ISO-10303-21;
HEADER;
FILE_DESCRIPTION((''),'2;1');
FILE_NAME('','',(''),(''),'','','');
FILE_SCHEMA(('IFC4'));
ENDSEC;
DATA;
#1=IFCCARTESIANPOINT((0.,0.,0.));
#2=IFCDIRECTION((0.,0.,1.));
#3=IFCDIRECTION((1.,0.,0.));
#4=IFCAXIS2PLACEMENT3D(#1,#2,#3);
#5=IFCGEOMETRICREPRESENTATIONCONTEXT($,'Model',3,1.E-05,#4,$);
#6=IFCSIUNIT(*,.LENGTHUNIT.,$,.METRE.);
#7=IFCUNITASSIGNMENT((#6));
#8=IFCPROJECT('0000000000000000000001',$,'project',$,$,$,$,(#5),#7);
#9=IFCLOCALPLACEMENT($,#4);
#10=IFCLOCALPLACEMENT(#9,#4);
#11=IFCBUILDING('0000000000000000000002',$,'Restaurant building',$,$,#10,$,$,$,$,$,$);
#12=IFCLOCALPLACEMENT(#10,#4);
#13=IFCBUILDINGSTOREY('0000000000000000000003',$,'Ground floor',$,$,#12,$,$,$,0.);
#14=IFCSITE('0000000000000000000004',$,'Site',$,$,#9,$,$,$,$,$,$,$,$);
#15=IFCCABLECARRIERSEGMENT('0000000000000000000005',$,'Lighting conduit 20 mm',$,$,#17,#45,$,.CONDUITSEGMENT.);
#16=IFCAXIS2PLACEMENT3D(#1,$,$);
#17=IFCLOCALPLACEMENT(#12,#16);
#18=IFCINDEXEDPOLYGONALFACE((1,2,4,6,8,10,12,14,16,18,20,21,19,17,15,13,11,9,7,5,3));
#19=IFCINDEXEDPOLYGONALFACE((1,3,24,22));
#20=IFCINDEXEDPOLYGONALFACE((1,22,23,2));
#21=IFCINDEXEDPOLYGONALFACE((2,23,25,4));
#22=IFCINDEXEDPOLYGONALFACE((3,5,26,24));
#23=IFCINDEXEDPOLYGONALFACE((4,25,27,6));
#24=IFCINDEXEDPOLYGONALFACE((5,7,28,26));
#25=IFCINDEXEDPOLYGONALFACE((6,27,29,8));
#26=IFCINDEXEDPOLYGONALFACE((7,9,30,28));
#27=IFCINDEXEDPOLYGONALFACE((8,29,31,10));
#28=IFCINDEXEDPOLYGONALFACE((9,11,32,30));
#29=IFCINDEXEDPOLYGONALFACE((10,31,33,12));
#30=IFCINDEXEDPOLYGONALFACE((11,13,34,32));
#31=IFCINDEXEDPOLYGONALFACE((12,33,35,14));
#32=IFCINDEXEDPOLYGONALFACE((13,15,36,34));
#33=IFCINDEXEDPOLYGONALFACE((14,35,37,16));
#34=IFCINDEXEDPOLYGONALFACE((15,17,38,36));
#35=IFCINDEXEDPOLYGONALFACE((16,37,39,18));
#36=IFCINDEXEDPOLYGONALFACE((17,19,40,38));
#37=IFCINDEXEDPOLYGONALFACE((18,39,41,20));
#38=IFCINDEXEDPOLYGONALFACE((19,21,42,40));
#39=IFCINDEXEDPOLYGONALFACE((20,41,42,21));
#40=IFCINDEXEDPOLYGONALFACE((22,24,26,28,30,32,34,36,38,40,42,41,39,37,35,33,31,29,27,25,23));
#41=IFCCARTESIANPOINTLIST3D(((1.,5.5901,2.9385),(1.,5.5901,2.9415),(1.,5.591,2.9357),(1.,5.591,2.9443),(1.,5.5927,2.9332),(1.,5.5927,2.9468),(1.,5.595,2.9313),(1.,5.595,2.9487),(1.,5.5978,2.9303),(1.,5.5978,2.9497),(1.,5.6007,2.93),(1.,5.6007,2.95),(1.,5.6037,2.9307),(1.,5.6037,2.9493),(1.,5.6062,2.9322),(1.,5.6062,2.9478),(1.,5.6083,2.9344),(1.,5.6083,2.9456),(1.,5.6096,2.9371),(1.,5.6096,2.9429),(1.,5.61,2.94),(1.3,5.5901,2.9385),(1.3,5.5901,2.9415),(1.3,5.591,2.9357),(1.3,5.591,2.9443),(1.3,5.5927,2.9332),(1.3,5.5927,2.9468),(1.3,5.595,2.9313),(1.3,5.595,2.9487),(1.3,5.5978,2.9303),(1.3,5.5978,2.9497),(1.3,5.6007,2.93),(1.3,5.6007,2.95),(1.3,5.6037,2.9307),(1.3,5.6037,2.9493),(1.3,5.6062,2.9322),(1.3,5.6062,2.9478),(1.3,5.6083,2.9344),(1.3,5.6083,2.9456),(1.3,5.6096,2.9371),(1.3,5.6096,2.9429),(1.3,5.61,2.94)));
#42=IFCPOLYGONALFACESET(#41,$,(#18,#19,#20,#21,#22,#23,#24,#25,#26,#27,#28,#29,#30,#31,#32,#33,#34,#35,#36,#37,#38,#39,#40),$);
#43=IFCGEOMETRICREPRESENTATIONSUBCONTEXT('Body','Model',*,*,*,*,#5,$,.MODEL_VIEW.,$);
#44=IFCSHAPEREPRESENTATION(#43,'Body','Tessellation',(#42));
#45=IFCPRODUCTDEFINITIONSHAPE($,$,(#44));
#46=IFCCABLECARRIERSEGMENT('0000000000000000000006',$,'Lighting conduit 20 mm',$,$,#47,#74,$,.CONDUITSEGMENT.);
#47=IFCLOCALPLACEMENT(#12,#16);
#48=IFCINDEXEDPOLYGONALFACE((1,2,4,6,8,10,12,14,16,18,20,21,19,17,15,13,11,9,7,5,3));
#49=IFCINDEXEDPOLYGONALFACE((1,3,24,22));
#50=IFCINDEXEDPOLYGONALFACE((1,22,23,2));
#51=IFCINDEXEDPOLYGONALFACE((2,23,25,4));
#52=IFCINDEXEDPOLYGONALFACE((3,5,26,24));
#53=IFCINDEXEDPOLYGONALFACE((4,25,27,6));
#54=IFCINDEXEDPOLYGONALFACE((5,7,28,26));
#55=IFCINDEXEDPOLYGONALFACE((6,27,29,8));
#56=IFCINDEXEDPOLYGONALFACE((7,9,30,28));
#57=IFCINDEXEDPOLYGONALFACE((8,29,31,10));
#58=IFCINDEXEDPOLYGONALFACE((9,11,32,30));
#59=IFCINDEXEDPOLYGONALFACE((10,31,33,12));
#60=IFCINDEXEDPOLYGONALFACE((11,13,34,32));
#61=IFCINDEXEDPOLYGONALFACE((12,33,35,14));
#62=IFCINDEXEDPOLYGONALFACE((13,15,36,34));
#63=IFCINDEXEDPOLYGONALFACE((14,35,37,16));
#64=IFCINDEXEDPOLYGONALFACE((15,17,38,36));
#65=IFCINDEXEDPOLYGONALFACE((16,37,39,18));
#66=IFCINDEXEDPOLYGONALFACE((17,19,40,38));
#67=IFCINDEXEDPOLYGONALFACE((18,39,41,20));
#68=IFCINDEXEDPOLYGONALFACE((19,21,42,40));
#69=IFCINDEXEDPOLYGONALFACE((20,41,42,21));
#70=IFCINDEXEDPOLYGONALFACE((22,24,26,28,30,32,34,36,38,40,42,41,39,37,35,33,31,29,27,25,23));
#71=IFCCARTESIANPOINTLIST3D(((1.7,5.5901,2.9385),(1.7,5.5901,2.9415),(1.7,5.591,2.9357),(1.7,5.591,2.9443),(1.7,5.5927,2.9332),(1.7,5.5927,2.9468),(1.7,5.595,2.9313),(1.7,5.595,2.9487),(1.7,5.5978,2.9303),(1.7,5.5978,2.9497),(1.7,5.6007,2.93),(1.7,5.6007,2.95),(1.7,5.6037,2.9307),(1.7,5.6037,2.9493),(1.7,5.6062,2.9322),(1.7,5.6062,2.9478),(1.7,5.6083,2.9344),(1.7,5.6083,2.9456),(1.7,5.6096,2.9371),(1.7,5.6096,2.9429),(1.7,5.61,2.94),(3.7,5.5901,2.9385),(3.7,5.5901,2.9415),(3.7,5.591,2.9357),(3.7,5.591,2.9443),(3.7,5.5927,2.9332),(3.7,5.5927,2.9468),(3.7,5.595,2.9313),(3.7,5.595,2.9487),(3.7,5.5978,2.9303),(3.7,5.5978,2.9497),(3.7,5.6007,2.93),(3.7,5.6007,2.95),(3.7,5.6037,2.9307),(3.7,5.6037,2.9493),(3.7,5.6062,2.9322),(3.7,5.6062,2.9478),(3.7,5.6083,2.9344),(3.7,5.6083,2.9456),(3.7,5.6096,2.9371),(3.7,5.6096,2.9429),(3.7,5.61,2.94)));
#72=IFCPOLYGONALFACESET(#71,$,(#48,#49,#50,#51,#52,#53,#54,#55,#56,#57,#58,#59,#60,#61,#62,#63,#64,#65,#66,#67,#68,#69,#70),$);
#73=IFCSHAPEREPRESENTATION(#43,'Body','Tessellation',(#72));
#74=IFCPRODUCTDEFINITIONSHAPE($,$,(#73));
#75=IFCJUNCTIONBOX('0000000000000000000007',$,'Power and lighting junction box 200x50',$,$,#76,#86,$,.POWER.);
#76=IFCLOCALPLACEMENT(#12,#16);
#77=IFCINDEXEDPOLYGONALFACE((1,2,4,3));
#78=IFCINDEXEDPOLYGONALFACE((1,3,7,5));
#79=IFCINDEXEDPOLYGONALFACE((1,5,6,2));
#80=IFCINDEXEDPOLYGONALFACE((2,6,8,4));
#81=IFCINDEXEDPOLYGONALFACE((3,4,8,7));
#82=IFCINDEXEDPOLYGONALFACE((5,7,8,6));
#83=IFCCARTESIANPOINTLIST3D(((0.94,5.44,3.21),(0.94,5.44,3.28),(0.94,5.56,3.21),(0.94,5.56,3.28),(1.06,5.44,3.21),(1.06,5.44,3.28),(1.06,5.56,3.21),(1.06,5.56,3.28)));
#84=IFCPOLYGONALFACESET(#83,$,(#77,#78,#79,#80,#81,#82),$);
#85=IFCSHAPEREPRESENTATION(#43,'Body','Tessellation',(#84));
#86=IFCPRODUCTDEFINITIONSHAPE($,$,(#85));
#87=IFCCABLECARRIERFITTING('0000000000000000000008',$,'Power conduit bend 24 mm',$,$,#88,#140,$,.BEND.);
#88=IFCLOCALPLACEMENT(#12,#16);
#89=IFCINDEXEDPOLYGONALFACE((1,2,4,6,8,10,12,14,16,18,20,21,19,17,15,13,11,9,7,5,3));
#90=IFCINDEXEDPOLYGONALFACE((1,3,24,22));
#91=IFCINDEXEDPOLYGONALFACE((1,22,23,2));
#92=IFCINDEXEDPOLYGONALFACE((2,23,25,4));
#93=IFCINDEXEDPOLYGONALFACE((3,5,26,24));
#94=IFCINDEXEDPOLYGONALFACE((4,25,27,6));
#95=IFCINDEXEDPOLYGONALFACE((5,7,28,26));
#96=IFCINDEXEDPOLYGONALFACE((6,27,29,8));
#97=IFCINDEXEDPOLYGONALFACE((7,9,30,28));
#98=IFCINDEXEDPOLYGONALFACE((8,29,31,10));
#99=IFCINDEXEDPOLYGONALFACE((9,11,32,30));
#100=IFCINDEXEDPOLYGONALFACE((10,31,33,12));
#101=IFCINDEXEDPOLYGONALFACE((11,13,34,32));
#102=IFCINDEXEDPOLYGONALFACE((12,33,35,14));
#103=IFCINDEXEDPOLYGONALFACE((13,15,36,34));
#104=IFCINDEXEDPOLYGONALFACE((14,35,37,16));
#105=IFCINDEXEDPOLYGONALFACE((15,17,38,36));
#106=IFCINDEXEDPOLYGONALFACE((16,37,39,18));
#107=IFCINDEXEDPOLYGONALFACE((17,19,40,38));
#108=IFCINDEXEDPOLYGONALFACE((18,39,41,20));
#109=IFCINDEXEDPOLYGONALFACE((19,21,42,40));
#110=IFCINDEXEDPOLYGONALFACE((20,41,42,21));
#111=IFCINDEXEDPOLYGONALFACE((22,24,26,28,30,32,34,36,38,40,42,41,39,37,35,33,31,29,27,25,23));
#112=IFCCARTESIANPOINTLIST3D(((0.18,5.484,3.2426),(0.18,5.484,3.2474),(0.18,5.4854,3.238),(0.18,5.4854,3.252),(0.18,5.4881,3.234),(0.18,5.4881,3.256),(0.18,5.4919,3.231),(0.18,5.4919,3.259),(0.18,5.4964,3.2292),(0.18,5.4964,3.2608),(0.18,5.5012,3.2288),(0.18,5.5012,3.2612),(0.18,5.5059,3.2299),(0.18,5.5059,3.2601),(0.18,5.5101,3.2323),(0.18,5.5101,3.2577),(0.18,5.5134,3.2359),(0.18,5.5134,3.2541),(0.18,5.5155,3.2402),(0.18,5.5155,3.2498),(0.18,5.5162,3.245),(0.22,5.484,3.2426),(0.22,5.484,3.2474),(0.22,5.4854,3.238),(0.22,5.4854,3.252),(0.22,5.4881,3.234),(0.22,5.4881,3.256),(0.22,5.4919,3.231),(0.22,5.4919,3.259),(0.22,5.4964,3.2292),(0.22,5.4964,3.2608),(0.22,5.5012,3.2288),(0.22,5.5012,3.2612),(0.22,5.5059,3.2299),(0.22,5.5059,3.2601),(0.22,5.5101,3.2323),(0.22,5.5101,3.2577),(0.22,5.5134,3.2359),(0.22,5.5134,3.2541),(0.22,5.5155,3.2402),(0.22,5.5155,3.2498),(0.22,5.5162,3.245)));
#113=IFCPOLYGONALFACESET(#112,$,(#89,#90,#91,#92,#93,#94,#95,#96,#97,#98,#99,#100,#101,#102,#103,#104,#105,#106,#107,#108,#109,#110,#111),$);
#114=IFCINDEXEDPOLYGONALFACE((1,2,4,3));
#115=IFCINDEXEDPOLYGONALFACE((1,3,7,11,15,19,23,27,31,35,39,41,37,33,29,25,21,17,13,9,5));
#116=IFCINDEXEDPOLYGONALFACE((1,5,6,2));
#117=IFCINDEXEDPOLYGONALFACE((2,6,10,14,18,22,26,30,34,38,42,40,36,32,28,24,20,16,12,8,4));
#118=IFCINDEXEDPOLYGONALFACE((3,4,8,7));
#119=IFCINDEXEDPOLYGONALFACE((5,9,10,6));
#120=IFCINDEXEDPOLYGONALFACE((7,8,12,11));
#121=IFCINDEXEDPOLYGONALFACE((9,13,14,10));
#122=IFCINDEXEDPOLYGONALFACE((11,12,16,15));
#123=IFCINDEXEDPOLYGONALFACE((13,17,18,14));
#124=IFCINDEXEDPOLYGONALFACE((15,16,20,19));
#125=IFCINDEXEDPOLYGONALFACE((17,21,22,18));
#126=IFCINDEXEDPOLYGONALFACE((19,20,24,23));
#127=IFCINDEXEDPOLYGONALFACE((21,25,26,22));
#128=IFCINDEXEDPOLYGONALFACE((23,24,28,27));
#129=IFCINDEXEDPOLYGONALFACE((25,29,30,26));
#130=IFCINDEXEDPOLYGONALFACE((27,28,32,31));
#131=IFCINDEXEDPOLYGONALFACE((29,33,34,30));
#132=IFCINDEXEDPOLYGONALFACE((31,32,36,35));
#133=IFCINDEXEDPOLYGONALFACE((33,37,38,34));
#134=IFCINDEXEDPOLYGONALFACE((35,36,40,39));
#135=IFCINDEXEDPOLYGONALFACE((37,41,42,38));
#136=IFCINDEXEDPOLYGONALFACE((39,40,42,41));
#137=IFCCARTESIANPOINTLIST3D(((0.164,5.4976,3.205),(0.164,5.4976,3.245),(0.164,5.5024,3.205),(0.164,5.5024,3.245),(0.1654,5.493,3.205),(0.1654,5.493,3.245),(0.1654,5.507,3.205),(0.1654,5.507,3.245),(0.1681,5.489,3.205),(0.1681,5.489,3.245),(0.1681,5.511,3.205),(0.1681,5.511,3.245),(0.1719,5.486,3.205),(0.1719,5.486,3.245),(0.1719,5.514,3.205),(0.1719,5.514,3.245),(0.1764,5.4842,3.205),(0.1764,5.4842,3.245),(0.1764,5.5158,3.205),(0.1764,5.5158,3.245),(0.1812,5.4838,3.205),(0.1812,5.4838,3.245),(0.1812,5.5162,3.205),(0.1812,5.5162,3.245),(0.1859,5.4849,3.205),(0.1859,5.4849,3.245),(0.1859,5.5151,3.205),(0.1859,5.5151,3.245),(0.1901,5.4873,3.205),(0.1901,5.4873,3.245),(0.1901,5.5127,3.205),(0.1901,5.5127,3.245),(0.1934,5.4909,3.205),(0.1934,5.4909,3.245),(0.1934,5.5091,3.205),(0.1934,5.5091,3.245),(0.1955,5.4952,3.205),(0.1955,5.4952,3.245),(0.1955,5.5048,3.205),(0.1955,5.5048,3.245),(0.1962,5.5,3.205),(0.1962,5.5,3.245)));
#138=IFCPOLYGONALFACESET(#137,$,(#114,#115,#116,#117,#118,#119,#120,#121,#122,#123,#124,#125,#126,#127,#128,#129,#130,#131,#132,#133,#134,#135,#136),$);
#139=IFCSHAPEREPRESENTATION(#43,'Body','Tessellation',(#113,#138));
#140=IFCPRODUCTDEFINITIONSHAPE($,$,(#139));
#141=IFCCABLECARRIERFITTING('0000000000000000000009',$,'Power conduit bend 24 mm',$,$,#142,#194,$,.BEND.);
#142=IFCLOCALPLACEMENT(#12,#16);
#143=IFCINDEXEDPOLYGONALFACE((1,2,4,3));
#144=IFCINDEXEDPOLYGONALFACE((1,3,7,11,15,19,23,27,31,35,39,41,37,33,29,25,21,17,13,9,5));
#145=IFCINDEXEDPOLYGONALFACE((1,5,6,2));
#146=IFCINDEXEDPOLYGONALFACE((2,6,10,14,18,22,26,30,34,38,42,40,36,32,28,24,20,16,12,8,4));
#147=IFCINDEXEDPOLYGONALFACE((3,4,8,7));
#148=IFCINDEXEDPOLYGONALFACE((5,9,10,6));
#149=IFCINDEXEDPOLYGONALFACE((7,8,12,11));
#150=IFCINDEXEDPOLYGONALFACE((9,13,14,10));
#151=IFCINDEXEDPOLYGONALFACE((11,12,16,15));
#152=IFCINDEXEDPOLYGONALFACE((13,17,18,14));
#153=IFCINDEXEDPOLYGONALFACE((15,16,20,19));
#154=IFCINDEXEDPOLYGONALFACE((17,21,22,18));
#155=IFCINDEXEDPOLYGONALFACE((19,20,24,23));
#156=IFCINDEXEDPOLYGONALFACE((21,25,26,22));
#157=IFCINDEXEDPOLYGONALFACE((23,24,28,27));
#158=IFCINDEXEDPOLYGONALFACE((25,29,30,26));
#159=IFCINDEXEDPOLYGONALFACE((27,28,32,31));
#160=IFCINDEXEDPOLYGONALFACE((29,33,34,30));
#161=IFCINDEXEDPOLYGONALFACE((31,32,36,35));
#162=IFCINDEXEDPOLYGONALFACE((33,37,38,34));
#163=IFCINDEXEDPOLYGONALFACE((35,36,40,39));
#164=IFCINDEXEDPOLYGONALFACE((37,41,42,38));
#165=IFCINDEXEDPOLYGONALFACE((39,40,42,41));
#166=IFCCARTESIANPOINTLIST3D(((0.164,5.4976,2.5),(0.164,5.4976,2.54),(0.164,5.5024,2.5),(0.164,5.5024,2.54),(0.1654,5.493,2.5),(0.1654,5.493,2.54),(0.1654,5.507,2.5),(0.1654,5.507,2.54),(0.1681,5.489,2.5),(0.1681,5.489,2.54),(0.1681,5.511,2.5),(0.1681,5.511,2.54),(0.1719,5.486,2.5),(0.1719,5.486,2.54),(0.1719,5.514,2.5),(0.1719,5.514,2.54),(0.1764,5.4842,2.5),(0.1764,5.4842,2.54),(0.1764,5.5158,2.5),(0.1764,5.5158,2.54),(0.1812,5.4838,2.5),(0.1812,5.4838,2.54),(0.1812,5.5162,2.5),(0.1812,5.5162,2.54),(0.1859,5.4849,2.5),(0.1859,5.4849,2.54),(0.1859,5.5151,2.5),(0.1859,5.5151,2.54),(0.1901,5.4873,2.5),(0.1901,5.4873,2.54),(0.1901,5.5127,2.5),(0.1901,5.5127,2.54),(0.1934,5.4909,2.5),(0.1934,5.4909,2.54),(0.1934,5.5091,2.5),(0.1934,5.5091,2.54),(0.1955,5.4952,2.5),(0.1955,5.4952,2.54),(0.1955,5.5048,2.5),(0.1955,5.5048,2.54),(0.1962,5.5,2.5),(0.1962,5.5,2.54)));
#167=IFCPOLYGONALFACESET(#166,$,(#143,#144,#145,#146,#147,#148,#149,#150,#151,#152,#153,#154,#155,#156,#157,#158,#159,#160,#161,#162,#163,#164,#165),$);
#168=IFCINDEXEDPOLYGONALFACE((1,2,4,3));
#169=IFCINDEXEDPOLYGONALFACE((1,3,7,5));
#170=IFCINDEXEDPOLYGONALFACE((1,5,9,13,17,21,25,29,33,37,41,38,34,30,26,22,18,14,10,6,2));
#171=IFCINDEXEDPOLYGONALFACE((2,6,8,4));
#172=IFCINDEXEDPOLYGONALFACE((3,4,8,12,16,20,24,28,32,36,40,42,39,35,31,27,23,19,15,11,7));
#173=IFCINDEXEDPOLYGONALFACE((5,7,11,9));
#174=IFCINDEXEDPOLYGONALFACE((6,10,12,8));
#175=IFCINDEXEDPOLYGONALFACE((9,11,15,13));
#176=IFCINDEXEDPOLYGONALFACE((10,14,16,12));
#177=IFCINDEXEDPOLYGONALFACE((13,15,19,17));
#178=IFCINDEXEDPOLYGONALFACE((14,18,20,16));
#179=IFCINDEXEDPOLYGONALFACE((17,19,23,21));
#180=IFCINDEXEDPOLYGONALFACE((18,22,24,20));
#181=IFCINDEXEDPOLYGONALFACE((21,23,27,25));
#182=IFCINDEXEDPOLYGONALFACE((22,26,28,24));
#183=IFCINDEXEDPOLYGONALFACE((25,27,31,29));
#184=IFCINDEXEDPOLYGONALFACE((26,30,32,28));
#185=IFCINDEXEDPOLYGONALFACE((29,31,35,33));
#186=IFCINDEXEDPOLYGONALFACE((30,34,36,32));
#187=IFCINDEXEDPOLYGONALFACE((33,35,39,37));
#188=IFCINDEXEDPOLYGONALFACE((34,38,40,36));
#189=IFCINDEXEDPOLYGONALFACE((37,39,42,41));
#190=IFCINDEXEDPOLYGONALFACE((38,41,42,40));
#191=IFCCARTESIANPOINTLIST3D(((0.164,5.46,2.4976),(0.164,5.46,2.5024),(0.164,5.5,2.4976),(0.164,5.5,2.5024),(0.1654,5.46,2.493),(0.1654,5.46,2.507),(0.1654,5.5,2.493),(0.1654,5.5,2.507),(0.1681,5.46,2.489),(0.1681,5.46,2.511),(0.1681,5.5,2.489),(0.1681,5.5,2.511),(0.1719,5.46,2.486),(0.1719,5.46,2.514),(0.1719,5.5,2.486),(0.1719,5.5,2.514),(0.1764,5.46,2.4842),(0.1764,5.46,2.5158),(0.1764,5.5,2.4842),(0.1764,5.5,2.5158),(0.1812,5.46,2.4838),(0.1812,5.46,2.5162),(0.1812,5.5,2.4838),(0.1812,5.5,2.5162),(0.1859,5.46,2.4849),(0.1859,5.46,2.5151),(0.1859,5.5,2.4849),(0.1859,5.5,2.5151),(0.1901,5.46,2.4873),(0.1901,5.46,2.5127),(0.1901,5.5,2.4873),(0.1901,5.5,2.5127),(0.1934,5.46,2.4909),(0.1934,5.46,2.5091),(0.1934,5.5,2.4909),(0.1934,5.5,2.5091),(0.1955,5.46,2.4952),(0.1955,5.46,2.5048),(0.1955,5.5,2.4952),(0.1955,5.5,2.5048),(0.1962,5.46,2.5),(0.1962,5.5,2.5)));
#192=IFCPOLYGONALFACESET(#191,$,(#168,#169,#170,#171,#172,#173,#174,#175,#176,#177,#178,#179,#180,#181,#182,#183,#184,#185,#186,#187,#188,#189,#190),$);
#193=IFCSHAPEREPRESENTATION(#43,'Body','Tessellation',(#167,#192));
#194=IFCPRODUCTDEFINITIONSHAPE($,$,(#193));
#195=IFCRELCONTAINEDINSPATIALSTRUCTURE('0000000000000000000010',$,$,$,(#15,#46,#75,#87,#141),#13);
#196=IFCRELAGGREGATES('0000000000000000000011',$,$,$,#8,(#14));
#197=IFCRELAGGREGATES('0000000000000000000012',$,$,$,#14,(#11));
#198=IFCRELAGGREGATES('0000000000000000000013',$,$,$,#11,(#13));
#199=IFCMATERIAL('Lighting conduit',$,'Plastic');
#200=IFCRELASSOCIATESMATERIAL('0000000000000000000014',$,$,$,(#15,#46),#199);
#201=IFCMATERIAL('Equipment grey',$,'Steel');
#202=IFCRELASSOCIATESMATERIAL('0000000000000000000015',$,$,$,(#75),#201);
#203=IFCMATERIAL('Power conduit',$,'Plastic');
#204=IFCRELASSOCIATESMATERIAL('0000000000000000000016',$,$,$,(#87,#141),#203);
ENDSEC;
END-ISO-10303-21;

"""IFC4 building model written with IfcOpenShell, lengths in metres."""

from ifc_helpers import new_model, si_unit, frame, origin, origin_with_axes, origin_2d, place, context, subcontext, project, spatial, rectangle, circle, extrude, material, element, save


model = new_model("IFC4")

# Units and contexts
model_context = context("Model", 3, precision=1e-05, world=origin_with_axes())
body_context = subcontext(model_context, "Body", "Model", "MODEL_VIEW")
ifc_project = project(units=[si_unit("LENGTHUNIT", "METRE")], contexts=[model_context])

# Site, building, storey
site_placement = place(None, origin_with_axes())
site = spatial("IfcSite", under=ifc_project, at=site_placement, Name="Site")
building_placement = place(site_placement, origin_with_axes())
building = spatial("IfcBuilding", under=site, at=building_placement, Name="Restaurant building")
storey_placement = place(building_placement, origin_with_axes())
storey = spatial("IfcBuildingStorey", under=building, at=storey_placement, Name="Ground floor", Elevation=0.0)

# Cable carrier segments
ifc_material_1 = material(Name="Power conduit", Category="Plastic")
ifc_material_2 = material(Name="Lighting conduit", Category="Plastic")
cable_carrier_segment_1_placement = place(storey_placement, frame((1.0, 5.6, 2.94)))
element("IfcCableCarrierSegment", 1, at=cable_carrier_segment_1_placement, inside=storey, material=ifc_material_2, Name="Lighting conduit 20 mm", PredefinedType="CONDUITSEGMENT", context=body_context, shape_type="SweptSolid", body=[
    extrude(circle(Radius=0.01, at=origin_2d()), frame((0.0, 0.0, 0.0), z_axis=(1.0, 0.0, 0.0), x_axis=(0.0, 1.0, 0.0)), (0.0, 0.0, 1.0), 0.3),
])
cable_carrier_segment_2_placement = place(storey_placement, frame((1.7, 5.6, 2.94)))
element("IfcCableCarrierSegment", 2, at=cable_carrier_segment_2_placement, inside=storey, material=ifc_material_2, Name="Lighting conduit 20 mm", PredefinedType="CONDUITSEGMENT", context=body_context, shape_type="SweptSolid", body=[
    extrude(circle(Radius=0.01, at=origin_2d()), frame((0.0, 0.0, 0.0), z_axis=(1.0, 0.0, 0.0), x_axis=(0.0, 1.0, 0.0)), (0.0, 0.0, 1.0), 2.0),
])

# Junction box
ifc_material_3 = material(Name="Equipment grey", Category="Steel")
junction_box_placement = place(storey_placement, frame((1.0, 5.5, 3.245)))
element("IfcJunctionBox", 3, at=junction_box_placement, inside=storey, material=ifc_material_3, Name="Power and lighting junction box 200x50", PredefinedType="POWER", context=body_context, shape_type="SweptSolid", body=[
    extrude(rectangle(XDim=0.12, YDim=0.12, at=origin_2d()), frame((0.0, 0.0, -0.035)), (0.0, 0.0, 1.0), 0.07),
])

# Cable carrier fittings
cable_carrier_fitting_1_placement = place(storey_placement, frame((0.18, 5.5, 3.245)))
element("IfcCableCarrierFitting", 4, at=cable_carrier_fitting_1_placement, inside=storey, material=ifc_material_1, Name="Power conduit bend 24 mm", PredefinedType="BEND", context=body_context, shape_type="SweptSolid", body=[
    extrude(circle(Radius=0.0162, at=origin_2d()), frame((0.0, 0.0, 0.0), z_axis=(1.0, 0.0, 0.0), x_axis=(0.0, 1.0, 0.0)), (0.0, 0.0, 1.0), 0.04),
    extrude(circle(Radius=0.0162, at=origin_2d()), frame((0.0, 0.0, 0.0), z_axis=(0.0, 0.0, -1.0), x_axis=(1.0, 0.0, 0.0)), (0.0, 0.0, 1.0), 0.04),
])
cable_carrier_fitting_2_placement = place(storey_placement, frame((0.18, 5.5, 2.5)))
element("IfcCableCarrierFitting", 5, at=cable_carrier_fitting_2_placement, inside=storey, material=ifc_material_1, Name="Power conduit bend 24 mm", PredefinedType="BEND", context=body_context, shape_type="SweptSolid", body=[
    extrude(circle(Radius=0.0162, at=origin_2d()), origin(), (0.0, 0.0, 1.0), 0.04),
    extrude(circle(Radius=0.0162, at=origin_2d()), frame((0.0, 0.0, 0.0), z_axis=(0.0, -1.0, 0.0), x_axis=(1.0, 0.0, 0.0)), (0.0, 0.0, 1.0), 0.04),
])

save(model, "model.ifc")
